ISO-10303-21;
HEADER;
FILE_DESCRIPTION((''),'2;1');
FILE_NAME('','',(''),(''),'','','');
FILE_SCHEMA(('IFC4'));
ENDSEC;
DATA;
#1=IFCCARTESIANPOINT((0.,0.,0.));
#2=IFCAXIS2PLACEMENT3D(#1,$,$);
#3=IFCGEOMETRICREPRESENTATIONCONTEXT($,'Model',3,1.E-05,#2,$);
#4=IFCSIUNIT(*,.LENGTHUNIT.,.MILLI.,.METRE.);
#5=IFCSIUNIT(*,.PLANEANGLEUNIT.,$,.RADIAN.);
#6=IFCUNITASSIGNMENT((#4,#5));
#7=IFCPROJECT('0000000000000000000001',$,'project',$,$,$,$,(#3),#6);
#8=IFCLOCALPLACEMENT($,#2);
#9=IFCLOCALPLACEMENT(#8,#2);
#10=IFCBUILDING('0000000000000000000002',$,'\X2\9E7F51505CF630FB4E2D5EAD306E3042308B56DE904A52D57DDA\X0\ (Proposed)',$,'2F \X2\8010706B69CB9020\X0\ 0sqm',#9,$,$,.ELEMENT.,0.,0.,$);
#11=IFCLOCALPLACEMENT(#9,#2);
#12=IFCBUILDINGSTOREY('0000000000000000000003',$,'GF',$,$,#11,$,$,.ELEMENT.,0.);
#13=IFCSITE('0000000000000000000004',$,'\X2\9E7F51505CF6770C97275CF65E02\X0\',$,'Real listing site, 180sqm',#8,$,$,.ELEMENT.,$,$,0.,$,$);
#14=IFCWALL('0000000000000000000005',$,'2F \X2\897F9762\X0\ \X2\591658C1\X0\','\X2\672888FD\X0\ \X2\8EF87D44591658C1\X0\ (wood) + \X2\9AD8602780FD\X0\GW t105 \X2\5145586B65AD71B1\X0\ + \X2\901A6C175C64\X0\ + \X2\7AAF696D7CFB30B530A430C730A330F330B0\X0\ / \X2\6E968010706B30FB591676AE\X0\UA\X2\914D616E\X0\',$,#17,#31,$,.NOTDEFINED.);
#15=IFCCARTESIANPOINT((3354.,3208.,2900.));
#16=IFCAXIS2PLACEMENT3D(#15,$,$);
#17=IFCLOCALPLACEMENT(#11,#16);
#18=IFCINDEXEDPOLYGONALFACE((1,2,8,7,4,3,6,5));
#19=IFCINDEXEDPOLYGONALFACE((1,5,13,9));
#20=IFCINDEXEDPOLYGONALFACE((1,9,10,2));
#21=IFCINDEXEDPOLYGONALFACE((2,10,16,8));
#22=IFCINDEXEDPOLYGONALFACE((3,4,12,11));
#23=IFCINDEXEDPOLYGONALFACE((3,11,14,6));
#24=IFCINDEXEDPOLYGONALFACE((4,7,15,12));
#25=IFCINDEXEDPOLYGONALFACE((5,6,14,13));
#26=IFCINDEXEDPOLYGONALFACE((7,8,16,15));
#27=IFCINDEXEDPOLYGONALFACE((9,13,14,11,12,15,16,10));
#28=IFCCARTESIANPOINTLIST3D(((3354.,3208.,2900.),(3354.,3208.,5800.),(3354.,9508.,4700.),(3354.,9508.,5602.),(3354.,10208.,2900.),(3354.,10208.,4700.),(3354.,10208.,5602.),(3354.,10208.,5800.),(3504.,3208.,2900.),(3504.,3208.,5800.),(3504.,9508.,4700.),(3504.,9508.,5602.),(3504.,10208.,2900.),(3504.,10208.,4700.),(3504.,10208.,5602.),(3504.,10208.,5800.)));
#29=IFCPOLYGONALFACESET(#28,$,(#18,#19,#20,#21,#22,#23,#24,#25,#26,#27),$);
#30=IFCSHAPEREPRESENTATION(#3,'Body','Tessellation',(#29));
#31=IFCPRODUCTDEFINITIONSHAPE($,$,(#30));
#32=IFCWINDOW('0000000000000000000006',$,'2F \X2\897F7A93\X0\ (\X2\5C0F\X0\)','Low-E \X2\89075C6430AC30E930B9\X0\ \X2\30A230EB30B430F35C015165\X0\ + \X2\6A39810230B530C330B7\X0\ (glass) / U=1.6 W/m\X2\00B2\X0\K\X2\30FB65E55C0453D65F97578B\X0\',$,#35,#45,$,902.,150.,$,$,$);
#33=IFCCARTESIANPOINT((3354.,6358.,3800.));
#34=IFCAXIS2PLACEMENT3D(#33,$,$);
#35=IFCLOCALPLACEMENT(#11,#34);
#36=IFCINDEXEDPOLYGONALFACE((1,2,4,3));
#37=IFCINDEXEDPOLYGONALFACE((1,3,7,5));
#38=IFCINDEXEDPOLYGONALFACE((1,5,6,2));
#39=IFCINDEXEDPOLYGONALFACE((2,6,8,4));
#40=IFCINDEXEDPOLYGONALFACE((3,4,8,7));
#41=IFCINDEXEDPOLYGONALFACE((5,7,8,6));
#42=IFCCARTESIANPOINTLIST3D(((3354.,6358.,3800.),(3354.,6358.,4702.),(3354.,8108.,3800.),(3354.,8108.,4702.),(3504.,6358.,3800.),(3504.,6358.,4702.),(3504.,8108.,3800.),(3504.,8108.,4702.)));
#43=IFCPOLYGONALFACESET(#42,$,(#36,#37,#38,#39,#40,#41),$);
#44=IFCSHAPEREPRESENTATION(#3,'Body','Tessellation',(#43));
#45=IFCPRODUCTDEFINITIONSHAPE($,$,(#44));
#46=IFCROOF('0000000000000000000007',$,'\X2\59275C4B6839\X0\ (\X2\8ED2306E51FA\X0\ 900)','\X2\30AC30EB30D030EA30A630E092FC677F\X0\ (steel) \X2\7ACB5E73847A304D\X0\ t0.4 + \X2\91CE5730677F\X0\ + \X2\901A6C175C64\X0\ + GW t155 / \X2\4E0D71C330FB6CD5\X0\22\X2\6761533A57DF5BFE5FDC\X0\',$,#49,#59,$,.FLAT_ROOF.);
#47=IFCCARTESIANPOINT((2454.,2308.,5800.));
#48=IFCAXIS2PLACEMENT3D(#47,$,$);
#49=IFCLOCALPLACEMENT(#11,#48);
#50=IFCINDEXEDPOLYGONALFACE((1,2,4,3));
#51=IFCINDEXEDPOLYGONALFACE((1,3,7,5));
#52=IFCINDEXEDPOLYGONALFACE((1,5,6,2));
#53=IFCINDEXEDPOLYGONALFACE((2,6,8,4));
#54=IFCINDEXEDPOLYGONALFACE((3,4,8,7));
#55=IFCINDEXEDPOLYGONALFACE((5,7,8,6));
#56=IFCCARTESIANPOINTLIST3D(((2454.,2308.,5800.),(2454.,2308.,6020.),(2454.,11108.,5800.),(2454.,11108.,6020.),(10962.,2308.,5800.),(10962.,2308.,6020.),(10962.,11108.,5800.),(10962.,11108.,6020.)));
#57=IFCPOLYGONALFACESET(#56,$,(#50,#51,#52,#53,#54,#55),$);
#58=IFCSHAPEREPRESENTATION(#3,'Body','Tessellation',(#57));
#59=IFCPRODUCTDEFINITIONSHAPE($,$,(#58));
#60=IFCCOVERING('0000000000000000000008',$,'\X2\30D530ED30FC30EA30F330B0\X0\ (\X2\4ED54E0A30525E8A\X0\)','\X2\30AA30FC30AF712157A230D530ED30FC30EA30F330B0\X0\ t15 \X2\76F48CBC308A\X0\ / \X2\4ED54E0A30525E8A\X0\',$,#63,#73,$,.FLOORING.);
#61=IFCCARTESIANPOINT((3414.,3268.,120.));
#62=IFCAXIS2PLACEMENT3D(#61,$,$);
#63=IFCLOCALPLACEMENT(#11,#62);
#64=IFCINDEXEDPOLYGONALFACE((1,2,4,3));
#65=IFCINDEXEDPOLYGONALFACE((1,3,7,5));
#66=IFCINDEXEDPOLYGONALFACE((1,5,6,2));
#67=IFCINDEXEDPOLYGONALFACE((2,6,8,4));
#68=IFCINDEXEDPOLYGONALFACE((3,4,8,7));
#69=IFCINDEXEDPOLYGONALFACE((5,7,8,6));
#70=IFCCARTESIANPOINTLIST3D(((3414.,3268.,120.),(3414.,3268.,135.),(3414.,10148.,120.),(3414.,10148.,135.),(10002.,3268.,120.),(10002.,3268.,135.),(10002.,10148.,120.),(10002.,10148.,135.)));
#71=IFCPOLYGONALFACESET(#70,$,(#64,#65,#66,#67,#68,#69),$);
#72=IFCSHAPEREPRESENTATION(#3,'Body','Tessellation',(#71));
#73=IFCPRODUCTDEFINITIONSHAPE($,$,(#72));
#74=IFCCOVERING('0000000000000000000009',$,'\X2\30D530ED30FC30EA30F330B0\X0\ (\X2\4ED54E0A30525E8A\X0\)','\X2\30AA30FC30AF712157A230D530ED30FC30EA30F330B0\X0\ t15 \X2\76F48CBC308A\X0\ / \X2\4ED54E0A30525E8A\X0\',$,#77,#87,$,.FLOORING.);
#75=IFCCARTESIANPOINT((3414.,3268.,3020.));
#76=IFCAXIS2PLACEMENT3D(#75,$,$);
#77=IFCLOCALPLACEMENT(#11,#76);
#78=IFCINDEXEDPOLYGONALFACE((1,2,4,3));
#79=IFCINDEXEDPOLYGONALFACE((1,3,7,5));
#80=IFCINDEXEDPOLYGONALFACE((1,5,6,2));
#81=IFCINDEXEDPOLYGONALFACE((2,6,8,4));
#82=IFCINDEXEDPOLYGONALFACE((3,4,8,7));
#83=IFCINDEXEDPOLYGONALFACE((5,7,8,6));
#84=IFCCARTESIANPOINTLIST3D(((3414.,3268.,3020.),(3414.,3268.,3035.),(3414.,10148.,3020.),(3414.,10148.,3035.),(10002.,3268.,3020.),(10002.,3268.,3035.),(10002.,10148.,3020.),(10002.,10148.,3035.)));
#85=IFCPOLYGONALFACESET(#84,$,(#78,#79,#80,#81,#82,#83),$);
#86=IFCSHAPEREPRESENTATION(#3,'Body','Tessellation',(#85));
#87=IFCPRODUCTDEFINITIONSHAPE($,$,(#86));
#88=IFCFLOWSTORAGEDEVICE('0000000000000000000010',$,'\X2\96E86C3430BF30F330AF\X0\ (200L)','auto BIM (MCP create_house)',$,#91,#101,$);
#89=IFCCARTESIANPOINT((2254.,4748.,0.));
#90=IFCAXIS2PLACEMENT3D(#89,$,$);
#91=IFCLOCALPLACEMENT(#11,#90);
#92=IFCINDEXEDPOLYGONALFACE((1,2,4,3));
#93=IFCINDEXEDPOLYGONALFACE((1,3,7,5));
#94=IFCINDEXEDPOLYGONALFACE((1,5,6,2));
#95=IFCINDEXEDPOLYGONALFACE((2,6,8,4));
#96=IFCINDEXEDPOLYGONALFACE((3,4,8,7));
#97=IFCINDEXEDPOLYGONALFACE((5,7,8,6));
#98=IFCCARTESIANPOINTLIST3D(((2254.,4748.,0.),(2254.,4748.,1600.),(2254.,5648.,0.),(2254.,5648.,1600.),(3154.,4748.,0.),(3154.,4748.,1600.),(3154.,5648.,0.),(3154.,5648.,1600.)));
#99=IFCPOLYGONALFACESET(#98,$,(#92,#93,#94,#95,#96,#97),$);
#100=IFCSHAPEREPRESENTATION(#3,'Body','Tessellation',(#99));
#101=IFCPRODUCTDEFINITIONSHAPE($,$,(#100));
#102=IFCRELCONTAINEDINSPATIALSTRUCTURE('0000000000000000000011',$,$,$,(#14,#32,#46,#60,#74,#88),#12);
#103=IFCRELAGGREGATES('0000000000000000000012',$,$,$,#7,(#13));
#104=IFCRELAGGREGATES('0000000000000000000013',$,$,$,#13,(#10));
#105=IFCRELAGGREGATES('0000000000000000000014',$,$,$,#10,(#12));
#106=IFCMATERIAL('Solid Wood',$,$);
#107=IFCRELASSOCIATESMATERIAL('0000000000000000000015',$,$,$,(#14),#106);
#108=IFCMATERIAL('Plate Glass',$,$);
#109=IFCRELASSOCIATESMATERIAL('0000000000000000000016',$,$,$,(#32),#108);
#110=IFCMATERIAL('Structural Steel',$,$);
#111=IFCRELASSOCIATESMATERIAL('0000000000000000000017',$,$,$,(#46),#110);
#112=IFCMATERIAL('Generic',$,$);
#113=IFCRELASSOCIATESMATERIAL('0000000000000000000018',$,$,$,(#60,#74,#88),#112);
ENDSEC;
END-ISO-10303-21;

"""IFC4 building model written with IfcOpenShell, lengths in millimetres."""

from ifc_helpers import new_model, si_unit, frame, frame_2d, origin, place, context, project, spatial, rectangle, extrude, material, element, fill, save


model = new_model("IFC4")

# Units and contexts
model_context = context("Model", 3, precision=1e-05, world=origin())
ifc_project = project(units=[si_unit("LENGTHUNIT", "METRE", prefix="MILLI"), si_unit("PLANEANGLEUNIT", "RADIAN")], contexts=[model_context])

# Site, building, storey
site_placement = place(None, origin())
site = spatial("IfcSite", under=ifc_project, at=site_placement, Name="鹿児島県霧島市", ObjectType="Real listing site, 180sqm", CompositionType="ELEMENT", RefElevation=0.0)
building_placement = place(site_placement, origin())
building = spatial("IfcBuilding", under=site, at=building_placement, Name="鹿児島・中庭のある回遊動線 (Proposed)", ObjectType="2F 耐火構造 0sqm", CompositionType="ELEMENT", ElevationOfRefHeight=0.0, ElevationOfTerrain=0.0)
storey_placement = place(building_placement, origin())
storey = spatial("IfcBuildingStorey", under=building, at=storey_placement, Name="GF", CompositionType="ELEMENT", Elevation=0.0)

# Shared definitions
ifc_material_1 = material(Name="Solid Wood")

# Shared definitions
ifc_material_2 = material(Name="Plate Glass")

# Wall, opening, window
wall_1_placement = place(storey_placement, frame((3354.0, 3208.0, 2900.0)))
wall_1 = element("IfcWall", 1, at=wall_1_placement, inside=storey, material=ifc_material_1, Name="2F 西面 外壁", Description="木製 軸組外壁 (wood) + 高性能GW t105 充填断熱 + 通気層 + 窯業系サイディング / 準耐火・外皮UA配慮", PredefinedType="NOTDEFINED", context=model_context, shape_type="SweptSolid", body=[
    extrude(rectangle(XDim=150.0, YDim=7000.0, at=frame_2d((75.0, 3500.0))), frame((3354.0, 3208.0, 2900.0)), (0.0, 0.0, 1.0), 2900.0),
])
opening_1_placement = place(storey_placement, frame((3354.0, 6358.0, 3800.0)))
opening_1 = element("IfcOpeningElement", 2, at=opening_1_placement, cuts=wall_1, PredefinedType="NOTDEFINED", context=model_context, shape_type="SweptSolid", body=[
    extrude(rectangle(XDim=150.0, YDim=1750.0, at=frame_2d((75.0, 875.0))), frame((3354.0, 6358.0, 3800.0)), (0.0, 0.0, 1.0), 902.0),
])
window_1_placement = place(storey_placement, frame((3354.0, 6358.0, 3800.0)))
window_1 = element("IfcWindow", 3, at=window_1_placement, inside=storey, material=ifc_material_2, Name="2F 西窓 (小)", Description="Low-E 複層ガラス アルゴン封入 + 樹脂サッシ (glass) / U=1.6 W/m²K・日射取得型", OverallHeight=902.0, OverallWidth=150.0, context=model_context, shape_type="SweptSolid", body=[
    extrude(rectangle(XDim=150.0, YDim=1750.0, at=frame_2d((75.0, 875.0))), frame((3354.0, 6358.0, 3800.0)), (0.0, 0.0, 1.0), 902.0),
])
fill(opening_1, window_1)

# Roof
ifc_material_3 = material(Name="Structural Steel")
roof_placement = place(storey_placement, frame((2454.0, 2308.0, 5800.0)))
element("IfcRoof", 4, at=roof_placement, inside=storey, material=ifc_material_3, Name="大屋根 (軒の出 900)", Description="ガルバリウム鋼板 (steel) 立平葺き t0.4 + 野地板 + 通気層 + GW t155 / 不燃・法22条区域対応", PredefinedType="FLAT_ROOF", context=model_context, shape_type="SweptSolid", body=[
    extrude(rectangle(XDim=8508.0, YDim=8800.0, at=frame_2d((4254.0, 4400.0))), frame((2454.0, 2308.0, 5800.0)), (0.0, 0.0, 1.0), 220.0),
])

# Coverings
ifc_material_4 = material(Name="Generic")
covering_1_placement = place(storey_placement, frame((3414.0, 3268.0, 120.0)))
element("IfcCovering", 5, at=covering_1_placement, inside=storey, material=ifc_material_4, Name="フローリング (仕上げ床)", Description="オーク無垢フローリング t15 直貼り / 仕上げ床", PredefinedType="FLOORING", context=model_context, shape_type="SweptSolid", body=[
    extrude(rectangle(XDim=6588.0, YDim=6880.0, at=frame_2d((3294.0, 3440.0))), frame((3414.0, 3268.0, 120.0)), (0.0, 0.0, 1.0), 15.0),
])
covering_2_placement = place(storey_placement, frame((3414.0, 3268.0, 3020.0)))
element("IfcCovering", 6, at=covering_2_placement, inside=storey, material=ifc_material_4, Name="フローリング (仕上げ床)", Description="オーク無垢フローリング t15 直貼り / 仕上げ床", PredefinedType="FLOORING", context=model_context, shape_type="SweptSolid", body=[
    extrude(rectangle(XDim=6588.0, YDim=6880.0, at=frame_2d((3294.0, 3440.0))), frame((3414.0, 3268.0, 3020.0)), (0.0, 0.0, 1.0), 15.0),
])

# Flow storage device
flow_storage_device_placement = place(storey_placement, frame((2254.0, 4748.0, 0.0)))
element("IfcFlowStorageDevice", 7, at=flow_storage_device_placement, inside=storey, material=ifc_material_4, Name="雨水タンク (200L)", Description="auto BIM (MCP create_house)", context=model_context, shape_type="SweptSolid", body=[
    extrude(rectangle(XDim=900.0, YDim=900.0, at=frame_2d((450.0, 450.0))), frame((2254.0, 4748.0, 0.0)), (0.0, 0.0, 1.0), 1600.0),
])

save(model, "model.ifc")
